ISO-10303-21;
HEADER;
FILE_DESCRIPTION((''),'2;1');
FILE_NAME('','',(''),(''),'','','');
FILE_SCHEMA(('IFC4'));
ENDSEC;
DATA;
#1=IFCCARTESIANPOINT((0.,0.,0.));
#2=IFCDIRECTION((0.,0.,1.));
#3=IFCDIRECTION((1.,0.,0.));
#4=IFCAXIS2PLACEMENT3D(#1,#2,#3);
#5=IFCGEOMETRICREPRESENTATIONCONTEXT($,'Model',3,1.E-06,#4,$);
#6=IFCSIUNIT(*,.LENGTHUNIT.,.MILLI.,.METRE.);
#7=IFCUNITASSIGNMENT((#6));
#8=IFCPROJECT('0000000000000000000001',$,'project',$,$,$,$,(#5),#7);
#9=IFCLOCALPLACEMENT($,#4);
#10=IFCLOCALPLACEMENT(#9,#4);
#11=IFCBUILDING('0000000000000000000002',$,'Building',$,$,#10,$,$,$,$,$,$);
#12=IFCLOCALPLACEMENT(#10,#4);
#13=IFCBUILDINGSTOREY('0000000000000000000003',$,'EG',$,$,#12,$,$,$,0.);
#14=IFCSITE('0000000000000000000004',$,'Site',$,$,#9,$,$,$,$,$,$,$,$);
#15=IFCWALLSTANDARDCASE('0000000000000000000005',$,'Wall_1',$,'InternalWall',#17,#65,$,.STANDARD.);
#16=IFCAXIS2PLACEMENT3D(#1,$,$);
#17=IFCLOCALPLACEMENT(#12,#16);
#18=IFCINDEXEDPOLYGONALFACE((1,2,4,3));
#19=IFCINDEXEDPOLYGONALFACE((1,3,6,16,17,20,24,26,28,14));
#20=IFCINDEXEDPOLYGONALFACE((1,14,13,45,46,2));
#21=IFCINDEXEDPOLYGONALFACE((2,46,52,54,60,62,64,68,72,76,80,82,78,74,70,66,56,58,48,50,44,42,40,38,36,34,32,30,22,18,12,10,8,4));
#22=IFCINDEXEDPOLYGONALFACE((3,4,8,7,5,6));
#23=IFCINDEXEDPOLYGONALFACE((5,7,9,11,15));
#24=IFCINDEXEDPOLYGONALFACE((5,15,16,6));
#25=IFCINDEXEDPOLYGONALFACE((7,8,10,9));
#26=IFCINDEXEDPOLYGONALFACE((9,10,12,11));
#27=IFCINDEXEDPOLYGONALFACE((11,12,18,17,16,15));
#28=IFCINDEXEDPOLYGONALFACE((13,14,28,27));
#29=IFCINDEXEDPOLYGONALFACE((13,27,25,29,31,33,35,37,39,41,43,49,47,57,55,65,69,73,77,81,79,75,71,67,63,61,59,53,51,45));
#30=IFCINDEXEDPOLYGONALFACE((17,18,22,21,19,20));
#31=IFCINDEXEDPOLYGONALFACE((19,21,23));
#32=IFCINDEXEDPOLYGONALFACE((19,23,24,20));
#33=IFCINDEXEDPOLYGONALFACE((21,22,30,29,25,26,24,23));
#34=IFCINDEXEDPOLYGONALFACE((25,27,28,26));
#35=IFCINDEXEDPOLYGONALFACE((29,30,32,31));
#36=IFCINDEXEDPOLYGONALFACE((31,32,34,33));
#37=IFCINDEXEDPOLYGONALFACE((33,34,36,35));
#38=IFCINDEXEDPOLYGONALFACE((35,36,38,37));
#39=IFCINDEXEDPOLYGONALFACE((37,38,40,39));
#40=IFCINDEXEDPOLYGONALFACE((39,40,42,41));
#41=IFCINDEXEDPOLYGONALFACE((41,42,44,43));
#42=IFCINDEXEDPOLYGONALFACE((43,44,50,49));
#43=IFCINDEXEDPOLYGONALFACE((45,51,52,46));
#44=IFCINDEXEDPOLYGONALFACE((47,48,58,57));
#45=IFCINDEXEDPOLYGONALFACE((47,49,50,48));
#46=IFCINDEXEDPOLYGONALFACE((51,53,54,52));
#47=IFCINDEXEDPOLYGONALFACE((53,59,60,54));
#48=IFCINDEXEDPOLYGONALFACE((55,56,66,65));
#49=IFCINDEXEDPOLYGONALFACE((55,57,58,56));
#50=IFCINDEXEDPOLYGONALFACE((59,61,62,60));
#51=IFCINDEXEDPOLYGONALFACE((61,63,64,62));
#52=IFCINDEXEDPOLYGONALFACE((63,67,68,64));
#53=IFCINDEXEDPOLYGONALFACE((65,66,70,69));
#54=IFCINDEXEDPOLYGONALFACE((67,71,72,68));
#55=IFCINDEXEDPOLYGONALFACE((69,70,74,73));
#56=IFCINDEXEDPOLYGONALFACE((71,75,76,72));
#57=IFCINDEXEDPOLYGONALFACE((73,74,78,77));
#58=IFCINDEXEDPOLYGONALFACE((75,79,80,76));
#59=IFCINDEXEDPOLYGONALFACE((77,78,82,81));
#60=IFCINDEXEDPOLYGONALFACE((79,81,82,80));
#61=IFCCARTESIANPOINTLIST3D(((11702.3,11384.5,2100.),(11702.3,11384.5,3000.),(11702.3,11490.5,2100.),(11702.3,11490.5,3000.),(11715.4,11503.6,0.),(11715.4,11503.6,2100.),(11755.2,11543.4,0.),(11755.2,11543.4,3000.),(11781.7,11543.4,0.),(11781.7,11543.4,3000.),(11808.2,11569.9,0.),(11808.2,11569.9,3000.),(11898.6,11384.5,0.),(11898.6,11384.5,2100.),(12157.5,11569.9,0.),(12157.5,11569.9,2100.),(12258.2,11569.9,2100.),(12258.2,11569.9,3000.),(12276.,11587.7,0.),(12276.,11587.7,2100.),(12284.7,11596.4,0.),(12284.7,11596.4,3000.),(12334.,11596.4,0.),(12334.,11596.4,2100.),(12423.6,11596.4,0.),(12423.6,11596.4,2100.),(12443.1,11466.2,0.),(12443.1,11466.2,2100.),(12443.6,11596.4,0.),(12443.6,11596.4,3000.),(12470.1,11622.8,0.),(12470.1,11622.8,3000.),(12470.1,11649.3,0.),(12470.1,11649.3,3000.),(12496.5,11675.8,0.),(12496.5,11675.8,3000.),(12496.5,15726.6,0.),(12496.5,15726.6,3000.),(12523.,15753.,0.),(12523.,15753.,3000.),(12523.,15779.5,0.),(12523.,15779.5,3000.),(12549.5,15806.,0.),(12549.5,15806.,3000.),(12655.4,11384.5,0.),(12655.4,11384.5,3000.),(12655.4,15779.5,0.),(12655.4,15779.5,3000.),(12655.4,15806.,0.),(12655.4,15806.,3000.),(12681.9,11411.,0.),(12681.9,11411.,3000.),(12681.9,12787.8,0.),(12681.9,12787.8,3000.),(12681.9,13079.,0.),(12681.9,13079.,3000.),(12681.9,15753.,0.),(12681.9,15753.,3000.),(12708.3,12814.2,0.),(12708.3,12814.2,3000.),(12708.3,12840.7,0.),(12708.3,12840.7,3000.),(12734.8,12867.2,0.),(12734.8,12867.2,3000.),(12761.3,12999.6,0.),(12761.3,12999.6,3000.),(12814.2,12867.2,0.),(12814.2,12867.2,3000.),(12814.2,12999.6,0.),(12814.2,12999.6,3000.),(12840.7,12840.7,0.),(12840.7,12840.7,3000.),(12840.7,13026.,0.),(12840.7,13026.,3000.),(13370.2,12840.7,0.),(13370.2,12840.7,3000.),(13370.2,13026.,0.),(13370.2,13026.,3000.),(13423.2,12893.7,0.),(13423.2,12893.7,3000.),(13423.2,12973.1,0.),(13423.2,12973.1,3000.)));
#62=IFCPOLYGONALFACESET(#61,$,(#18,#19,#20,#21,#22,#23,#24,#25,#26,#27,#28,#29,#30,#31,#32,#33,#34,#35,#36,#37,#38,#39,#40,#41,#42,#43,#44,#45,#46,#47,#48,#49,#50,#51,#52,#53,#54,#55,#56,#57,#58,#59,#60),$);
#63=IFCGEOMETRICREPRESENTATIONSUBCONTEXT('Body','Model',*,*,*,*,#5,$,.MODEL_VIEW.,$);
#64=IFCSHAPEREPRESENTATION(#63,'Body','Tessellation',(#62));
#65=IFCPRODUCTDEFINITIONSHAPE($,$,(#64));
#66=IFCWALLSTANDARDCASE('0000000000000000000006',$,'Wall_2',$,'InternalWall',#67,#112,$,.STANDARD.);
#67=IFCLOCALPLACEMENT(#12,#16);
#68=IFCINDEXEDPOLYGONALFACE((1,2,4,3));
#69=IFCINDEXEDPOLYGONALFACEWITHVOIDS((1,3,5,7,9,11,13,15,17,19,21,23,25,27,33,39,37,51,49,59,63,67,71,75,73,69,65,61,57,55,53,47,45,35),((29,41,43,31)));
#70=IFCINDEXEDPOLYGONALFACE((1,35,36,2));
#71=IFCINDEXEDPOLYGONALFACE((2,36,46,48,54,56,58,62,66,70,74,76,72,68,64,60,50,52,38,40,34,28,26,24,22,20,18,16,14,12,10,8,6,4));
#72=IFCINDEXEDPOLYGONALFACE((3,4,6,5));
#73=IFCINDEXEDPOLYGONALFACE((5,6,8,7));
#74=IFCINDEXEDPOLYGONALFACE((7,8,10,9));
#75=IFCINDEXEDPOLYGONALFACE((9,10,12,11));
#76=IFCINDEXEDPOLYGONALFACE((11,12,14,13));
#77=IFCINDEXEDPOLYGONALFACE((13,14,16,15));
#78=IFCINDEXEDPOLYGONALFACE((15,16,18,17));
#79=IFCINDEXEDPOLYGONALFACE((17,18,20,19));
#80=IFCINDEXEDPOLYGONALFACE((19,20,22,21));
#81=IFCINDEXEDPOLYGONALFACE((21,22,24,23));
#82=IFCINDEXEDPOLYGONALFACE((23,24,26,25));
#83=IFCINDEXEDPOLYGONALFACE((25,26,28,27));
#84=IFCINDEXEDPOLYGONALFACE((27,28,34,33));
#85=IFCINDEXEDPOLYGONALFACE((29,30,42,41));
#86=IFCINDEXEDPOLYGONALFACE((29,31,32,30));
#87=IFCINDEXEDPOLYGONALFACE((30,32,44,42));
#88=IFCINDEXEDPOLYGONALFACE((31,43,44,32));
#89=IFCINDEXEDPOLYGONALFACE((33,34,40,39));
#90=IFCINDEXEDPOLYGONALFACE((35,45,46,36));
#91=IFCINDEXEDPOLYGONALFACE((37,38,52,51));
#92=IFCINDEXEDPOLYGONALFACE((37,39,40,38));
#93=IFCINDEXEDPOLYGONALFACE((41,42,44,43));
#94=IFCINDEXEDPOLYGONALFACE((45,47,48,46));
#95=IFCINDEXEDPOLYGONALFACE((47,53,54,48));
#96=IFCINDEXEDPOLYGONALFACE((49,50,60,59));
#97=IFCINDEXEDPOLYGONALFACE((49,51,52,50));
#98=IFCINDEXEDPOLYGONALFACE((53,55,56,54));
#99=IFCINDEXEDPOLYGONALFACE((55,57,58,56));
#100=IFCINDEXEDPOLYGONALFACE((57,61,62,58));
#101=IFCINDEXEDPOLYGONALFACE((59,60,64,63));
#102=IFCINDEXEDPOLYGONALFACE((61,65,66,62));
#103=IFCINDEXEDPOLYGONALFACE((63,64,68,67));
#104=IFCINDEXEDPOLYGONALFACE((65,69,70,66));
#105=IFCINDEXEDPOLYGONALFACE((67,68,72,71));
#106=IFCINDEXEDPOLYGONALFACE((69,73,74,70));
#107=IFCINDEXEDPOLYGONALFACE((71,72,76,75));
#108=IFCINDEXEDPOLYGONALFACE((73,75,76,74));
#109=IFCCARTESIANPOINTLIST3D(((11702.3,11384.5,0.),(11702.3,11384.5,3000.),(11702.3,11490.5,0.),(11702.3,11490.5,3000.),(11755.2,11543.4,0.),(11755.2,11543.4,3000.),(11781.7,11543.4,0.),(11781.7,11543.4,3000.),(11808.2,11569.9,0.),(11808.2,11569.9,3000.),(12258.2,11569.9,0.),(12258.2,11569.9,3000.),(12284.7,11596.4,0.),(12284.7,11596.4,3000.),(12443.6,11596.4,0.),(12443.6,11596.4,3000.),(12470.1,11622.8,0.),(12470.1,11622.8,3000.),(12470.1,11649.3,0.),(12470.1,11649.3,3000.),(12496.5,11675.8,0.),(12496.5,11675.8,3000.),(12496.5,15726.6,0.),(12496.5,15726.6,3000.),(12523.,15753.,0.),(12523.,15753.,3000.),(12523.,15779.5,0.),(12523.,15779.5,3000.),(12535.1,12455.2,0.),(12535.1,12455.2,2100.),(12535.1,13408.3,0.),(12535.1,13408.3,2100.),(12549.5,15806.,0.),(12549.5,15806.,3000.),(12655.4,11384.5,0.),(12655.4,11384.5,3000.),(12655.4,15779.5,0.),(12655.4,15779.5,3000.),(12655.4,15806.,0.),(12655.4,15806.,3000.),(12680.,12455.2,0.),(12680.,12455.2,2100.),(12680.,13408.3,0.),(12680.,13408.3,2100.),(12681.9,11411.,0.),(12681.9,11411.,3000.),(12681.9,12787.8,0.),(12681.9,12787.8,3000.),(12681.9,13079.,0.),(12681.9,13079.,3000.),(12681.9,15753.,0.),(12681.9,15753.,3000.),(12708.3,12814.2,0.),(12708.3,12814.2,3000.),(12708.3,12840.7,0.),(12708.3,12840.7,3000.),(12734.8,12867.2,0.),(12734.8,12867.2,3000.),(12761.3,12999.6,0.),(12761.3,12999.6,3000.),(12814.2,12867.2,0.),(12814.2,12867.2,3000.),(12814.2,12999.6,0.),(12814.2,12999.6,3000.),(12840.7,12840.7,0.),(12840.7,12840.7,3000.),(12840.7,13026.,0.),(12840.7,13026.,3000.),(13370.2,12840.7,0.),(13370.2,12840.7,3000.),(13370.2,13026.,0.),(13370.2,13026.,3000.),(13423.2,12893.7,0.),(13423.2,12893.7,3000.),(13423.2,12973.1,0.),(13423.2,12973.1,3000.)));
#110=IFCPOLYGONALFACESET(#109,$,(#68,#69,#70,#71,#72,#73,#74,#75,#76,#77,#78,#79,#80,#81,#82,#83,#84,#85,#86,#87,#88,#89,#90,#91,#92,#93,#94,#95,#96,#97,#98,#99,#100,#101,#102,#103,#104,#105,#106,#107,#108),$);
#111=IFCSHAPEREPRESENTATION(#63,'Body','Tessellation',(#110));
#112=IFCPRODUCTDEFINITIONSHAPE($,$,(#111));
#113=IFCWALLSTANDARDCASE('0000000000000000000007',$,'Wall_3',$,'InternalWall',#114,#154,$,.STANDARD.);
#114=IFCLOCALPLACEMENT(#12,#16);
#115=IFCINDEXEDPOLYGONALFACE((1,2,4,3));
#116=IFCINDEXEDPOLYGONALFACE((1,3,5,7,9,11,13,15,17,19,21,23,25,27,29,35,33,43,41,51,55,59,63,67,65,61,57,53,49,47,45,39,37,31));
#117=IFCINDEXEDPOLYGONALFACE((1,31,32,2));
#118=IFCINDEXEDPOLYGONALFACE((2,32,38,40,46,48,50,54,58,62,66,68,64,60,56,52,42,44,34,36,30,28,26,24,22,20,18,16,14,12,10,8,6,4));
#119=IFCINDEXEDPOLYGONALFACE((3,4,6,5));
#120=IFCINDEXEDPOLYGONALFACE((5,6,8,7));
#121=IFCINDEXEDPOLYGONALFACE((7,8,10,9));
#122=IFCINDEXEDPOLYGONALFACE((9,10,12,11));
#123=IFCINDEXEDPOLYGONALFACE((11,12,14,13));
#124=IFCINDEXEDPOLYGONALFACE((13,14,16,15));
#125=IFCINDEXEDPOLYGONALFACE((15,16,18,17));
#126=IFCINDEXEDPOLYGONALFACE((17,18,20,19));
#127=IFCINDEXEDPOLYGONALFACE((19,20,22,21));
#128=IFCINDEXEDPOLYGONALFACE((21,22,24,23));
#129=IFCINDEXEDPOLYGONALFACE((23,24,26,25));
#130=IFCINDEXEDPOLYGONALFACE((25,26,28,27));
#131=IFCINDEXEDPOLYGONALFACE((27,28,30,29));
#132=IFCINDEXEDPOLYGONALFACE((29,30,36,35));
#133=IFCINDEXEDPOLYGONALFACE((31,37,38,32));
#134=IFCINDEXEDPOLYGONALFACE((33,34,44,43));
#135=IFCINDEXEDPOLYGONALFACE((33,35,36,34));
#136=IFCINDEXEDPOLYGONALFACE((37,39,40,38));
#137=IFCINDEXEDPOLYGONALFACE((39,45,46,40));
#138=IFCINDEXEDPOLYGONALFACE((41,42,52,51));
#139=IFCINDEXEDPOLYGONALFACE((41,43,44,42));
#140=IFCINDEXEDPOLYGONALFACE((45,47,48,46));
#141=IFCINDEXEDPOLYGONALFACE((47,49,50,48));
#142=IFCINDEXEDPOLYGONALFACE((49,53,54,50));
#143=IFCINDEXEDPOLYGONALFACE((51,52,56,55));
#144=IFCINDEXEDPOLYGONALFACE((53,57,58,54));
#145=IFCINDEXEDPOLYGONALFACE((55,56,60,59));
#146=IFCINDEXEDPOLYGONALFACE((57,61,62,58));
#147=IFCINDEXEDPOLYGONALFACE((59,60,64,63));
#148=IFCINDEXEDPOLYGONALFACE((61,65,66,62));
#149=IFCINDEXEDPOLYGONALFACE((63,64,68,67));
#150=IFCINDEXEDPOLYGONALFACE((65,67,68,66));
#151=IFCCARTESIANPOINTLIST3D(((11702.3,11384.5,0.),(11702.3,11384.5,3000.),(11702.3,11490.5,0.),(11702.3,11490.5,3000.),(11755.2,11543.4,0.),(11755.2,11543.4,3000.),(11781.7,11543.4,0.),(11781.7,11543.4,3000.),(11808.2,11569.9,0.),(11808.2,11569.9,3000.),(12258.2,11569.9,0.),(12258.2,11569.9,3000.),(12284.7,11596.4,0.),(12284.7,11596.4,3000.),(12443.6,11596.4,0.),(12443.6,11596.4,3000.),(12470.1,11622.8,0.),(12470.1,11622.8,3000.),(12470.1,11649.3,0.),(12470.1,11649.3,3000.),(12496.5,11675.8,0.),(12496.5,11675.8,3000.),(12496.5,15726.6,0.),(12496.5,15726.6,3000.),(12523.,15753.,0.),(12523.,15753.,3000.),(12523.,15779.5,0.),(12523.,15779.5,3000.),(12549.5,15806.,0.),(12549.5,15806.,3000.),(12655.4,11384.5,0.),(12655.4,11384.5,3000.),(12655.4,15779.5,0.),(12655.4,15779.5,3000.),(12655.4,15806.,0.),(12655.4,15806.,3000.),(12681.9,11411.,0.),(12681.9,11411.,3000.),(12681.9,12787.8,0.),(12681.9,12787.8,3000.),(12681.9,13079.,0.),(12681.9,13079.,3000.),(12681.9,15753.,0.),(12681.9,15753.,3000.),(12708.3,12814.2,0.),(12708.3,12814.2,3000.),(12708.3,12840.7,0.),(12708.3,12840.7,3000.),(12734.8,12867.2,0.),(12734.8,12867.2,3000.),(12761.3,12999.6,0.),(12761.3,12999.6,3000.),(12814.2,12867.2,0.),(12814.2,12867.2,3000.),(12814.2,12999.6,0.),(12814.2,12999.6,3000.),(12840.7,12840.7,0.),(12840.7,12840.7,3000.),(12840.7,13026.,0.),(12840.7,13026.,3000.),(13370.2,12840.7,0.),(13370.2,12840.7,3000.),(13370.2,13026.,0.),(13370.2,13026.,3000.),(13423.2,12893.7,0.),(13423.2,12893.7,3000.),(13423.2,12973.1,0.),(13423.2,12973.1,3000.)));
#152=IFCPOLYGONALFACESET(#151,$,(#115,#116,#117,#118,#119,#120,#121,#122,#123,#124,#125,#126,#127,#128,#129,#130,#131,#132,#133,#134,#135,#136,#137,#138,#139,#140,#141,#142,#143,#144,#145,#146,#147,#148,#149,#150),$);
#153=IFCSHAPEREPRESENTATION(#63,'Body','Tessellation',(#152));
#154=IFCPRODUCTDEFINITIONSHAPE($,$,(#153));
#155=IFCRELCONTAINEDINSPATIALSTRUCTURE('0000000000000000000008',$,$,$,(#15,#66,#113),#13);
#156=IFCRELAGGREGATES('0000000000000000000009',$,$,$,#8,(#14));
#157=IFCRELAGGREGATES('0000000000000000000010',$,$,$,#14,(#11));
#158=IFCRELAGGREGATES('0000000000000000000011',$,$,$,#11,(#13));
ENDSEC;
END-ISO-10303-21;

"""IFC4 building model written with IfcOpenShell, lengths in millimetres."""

from ifc_helpers import new_model, si_unit, frame, origin_with_axes, place, context, subcontext, project, spatial, polyline, rectangle, outline, extrude, element, save


model = new_model("IFC4")

# Units and contexts
model_context = context("Model", 3, precision=1e-06, world=origin_with_axes())
body_context = subcontext(model_context, "Body", "Model", "MODEL_VIEW")
ifc_project = project(units=[si_unit("LENGTHUNIT", "METRE", prefix="MILLI")], contexts=[model_context])

# Site, building, storey
site_placement = place(None, origin_with_axes())
site = spatial("IfcSite", under=ifc_project, at=site_placement, Name="Site")
building_placement = place(site_placement, origin_with_axes())
building = spatial("IfcBuilding", under=site, at=building_placement, Name="Building")
storey_placement = place(building_placement, origin_with_axes())
storey = spatial("IfcBuildingStorey", under=building, at=storey_placement, Name="EG", Elevation=0.0)

# Walls, openings
wall_1_placement = place(storey_placement, origin_with_axes())
wall_1 = element("IfcWallStandardCase", 1, at=wall_1_placement, inside=storey, Name="Wall_1", ObjectType="InternalWall", PredefinedType="STANDARD", context=body_context, shape_type="SweptSolid", body=[
    extrude(outline(polyline([(11702.3, 11384.5, 0.0), (11702.3, 11490.5, 0.0), (11755.2, 11543.4, 0.0), (11781.7, 11543.4, 0.0), (11808.2, 11569.9, 0.0), (12258.2, 11569.9, 0.0), (12284.7, 11596.4, 0.0), (12443.6, 11596.4, 0.0), (12470.1, 11622.8, 0.0), (12470.1, 11649.3, 0.0), (12496.5, 11675.8, 0.0), (12496.5, 15726.6, 0.0), (12523.0, 15753.0, 0.0), (12523.0, 15779.5, 0.0), (12549.5, 15806.0, 0.0), (12655.4, 15806.0, 0.0), (12655.4, 15779.5, 0.0), (12681.9, 15753.0, 0.0), (12681.9, 13079.0, 0.0), (12761.3, 12999.6, 0.0), (12814.2, 12999.6, 0.0), (12840.7, 13026.0, 0.0), (13370.2, 13026.0, 0.0), (13423.2, 12973.1, 0.0), (13423.2, 12893.7, 0.0), (13370.2, 12840.7, 0.0), (12840.7, 12840.7, 0.0), (12814.2, 12867.2, 0.0), (12734.8, 12867.2, 0.0), (12708.3, 12840.7, 0.0), (12708.3, 12814.2, 0.0), (12681.9, 12787.8, 0.0), (12681.9, 11411.0, 0.0), (12655.4, 11384.5, 0.0), (11702.3, 11384.5, 0.0)])), origin_with_axes(), (0.0, 0.0, 1.0), 3000.0),
])
opening_1_placement = place(wall_1_placement, origin_with_axes())
element("IfcOpeningElement", 2, at=opening_1_placement, inside=storey, cuts=wall_1, context=body_context, shape_type="SweptSolid", body=[
    extrude(rectangle(XDim=915.1, YDim=144.9), frame((11979.9, 11470.0, 0.0), z_axis=(0.0, 0.0, 1.0), x_axis=(-0.988936, -0.14834, 0.0)), (0.0, 0.0, 1.0), 2100.0),
])
wall_2_placement = place(storey_placement, origin_with_axes())
wall_2 = element("IfcWallStandardCase", 3, at=wall_2_placement, inside=storey, Name="Wall_2", ObjectType="InternalWall", PredefinedType="STANDARD", context=body_context, shape_type="SweptSolid", body=[
    extrude(outline(polyline([(11702.3, 11384.5, 0.0), (11702.3, 11490.5, 0.0), (11755.2, 11543.4, 0.0), (11781.7, 11543.4, 0.0), (11808.2, 11569.9, 0.0), (12258.2, 11569.9, 0.0), (12284.7, 11596.4, 0.0), (12443.6, 11596.4, 0.0), (12470.1, 11622.8, 0.0), (12470.1, 11649.3, 0.0), (12496.5, 11675.8, 0.0), (12496.5, 15726.6, 0.0), (12523.0, 15753.0, 0.0), (12523.0, 15779.5, 0.0), (12549.5, 15806.0, 0.0), (12655.4, 15806.0, 0.0), (12655.4, 15779.5, 0.0), (12681.9, 15753.0, 0.0), (12681.9, 13079.0, 0.0), (12761.3, 12999.6, 0.0), (12814.2, 12999.6, 0.0), (12840.7, 13026.0, 0.0), (13370.2, 13026.0, 0.0), (13423.2, 12973.1, 0.0), (13423.2, 12893.7, 0.0), (13370.2, 12840.7, 0.0), (12840.7, 12840.7, 0.0), (12814.2, 12867.2, 0.0), (12734.8, 12867.2, 0.0), (12708.3, 12840.7, 0.0), (12708.3, 12814.2, 0.0), (12681.9, 12787.8, 0.0), (12681.9, 11411.0, 0.0), (12655.4, 11384.5, 0.0), (11702.3, 11384.5, 0.0)])), origin_with_axes(), (0.0, 0.0, 1.0), 3000.0),
])
opening_2_placement = place(wall_2_placement, origin_with_axes())
element("IfcOpeningElement", 4, at=opening_2_placement, inside=storey, cuts=wall_2, context=body_context, shape_type="SweptSolid", body=[
    extrude(rectangle(XDim=953.1, YDim=144.9), frame((12607.6, 12931.8, 0.0), z_axis=(0.0, 0.0, 1.0), x_axis=(0.0, -1.0, 0.0)), (0.0, 0.0, 1.0), 2100.0),
])

# Wall
for number, where, z_axis, x_axis, name in (
    (5, (0.0, 0.0, 0.0), (0.0, 0.0, 1.0), (1.0, 0.0, 0.0), "Wall_3"),
):
    element("IfcWallStandardCase", number, at=place(storey_placement, frame(where, z_axis=z_axis, x_axis=x_axis)), inside=storey, Name=name, ObjectType="InternalWall", PredefinedType="STANDARD", context=body_context, shape_type="SweptSolid", body=[
        extrude(outline(polyline([(11702.3, 11384.5, 0.0), (11702.3, 11490.5, 0.0), (11755.2, 11543.4, 0.0), (11781.7, 11543.4, 0.0), (11808.2, 11569.9, 0.0), (12258.2, 11569.9, 0.0), (12284.7, 11596.4, 0.0), (12443.6, 11596.4, 0.0), (12470.1, 11622.8, 0.0), (12470.1, 11649.3, 0.0), (12496.5, 11675.8, 0.0), (12496.5, 15726.6, 0.0), (12523.0, 15753.0, 0.0), (12523.0, 15779.5, 0.0), (12549.5, 15806.0, 0.0), (12655.4, 15806.0, 0.0), (12655.4, 15779.5, 0.0), (12681.9, 15753.0, 0.0), (12681.9, 13079.0, 0.0), (12761.3, 12999.6, 0.0), (12814.2, 12999.6, 0.0), (12840.7, 13026.0, 0.0), (13370.2, 13026.0, 0.0), (13423.2, 12973.1, 0.0), (13423.2, 12893.7, 0.0), (13370.2, 12840.7, 0.0), (12840.7, 12840.7, 0.0), (12814.2, 12867.2, 0.0), (12734.8, 12867.2, 0.0), (12708.3, 12840.7, 0.0), (12708.3, 12814.2, 0.0), (12681.9, 12787.8, 0.0), (12681.9, 11411.0, 0.0), (12655.4, 11384.5, 0.0), (11702.3, 11384.5, 0.0)])), origin_with_axes(), (0.0, 0.0, 1.0), 3000.0),
    ])

save(model, "model.ifc")
